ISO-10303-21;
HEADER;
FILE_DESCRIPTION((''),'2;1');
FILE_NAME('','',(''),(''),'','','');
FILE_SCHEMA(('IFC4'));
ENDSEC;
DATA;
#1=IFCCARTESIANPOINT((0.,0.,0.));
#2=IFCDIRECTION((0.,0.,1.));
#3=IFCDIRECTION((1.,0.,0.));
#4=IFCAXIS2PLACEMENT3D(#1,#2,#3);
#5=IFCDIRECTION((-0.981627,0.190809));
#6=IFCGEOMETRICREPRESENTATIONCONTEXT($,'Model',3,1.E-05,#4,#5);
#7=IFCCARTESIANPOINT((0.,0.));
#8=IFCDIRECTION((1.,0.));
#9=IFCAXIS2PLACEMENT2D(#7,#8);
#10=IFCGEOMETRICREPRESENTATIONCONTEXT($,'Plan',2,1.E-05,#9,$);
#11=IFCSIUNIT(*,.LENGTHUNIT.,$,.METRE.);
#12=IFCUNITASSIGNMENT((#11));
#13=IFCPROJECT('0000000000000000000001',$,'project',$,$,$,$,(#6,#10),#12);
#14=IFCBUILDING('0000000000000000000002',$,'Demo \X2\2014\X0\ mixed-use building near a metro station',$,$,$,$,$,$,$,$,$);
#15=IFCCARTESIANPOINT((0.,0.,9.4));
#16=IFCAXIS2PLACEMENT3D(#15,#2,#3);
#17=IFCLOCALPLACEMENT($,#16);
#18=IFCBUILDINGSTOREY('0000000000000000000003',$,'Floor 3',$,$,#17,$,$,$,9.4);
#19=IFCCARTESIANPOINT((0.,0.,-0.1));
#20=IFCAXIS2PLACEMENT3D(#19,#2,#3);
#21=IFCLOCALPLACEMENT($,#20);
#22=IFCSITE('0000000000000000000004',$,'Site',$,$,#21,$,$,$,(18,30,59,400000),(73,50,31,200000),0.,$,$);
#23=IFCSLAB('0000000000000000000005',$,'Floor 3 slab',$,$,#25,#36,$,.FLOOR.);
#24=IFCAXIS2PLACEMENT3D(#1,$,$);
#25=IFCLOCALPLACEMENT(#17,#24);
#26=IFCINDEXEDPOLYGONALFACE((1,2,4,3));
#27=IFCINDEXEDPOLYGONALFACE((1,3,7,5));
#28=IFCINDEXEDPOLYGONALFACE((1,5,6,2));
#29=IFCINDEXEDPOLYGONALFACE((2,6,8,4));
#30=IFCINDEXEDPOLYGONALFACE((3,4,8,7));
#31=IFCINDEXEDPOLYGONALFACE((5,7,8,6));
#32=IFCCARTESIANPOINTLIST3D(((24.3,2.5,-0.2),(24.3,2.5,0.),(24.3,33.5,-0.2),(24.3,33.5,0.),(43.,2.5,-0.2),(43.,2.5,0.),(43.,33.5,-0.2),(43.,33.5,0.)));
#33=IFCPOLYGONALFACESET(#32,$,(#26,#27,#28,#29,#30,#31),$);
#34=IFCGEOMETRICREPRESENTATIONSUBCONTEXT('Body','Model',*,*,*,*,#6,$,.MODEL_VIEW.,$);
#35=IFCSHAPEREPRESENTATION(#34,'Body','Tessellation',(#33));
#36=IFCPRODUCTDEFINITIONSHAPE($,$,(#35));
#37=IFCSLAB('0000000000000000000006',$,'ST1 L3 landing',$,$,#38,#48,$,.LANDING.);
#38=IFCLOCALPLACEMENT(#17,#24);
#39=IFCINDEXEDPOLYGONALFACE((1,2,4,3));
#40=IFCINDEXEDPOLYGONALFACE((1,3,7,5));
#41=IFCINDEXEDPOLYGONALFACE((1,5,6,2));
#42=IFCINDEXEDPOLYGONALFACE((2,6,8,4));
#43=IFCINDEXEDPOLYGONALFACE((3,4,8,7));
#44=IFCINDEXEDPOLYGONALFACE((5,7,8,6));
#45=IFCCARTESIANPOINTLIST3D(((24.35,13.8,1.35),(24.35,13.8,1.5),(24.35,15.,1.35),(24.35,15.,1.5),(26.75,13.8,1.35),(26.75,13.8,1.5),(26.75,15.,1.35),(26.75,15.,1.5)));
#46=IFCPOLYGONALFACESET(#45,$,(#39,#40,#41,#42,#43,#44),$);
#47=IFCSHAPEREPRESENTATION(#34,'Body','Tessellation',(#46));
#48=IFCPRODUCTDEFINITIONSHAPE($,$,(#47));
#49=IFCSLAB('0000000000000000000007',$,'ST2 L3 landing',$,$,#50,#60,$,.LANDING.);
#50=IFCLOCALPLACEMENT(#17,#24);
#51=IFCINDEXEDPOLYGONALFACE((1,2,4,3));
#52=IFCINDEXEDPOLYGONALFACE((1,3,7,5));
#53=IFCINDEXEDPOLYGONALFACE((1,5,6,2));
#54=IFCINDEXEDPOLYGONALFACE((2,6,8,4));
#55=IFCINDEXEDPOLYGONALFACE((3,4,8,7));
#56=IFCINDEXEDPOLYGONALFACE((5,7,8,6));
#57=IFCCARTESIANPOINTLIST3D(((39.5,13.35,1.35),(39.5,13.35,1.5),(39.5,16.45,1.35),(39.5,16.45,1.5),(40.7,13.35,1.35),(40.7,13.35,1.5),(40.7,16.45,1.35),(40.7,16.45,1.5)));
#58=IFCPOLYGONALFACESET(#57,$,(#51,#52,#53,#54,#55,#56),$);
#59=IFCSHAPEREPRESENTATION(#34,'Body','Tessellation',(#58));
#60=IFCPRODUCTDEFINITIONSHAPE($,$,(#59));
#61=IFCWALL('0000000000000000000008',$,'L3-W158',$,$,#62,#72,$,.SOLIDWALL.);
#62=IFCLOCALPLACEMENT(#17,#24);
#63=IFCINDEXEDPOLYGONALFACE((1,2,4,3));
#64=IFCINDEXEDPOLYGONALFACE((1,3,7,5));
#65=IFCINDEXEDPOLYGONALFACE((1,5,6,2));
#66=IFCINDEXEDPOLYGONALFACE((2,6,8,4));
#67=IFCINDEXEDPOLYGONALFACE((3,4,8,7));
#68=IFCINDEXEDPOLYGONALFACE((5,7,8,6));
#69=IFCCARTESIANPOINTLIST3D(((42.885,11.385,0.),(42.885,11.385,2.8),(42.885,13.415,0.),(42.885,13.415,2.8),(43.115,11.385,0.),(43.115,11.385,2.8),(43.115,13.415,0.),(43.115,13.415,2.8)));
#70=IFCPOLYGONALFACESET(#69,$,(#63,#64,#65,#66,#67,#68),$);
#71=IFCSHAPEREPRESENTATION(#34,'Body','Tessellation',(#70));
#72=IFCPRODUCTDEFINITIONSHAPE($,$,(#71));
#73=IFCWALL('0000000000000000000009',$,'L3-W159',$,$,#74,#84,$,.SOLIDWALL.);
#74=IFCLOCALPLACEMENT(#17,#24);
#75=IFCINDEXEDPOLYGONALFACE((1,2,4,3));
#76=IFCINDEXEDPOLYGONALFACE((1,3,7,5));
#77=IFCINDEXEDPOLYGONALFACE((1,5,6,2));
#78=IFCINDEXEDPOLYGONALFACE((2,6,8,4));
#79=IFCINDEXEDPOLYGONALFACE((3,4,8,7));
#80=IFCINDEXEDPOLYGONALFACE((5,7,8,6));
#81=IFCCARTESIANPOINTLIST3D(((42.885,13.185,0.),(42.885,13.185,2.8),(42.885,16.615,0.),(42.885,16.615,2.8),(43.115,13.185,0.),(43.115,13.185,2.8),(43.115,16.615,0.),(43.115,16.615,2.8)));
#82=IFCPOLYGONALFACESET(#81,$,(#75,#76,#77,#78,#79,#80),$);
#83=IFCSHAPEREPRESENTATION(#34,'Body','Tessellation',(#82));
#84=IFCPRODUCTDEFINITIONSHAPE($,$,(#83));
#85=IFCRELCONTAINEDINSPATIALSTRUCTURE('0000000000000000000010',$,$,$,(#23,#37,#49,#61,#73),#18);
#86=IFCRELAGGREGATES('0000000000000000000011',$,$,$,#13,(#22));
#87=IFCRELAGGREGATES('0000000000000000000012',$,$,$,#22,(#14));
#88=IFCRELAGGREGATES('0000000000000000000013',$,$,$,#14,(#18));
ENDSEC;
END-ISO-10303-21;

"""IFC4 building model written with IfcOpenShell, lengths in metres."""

from ifc_helpers import new_model, si_unit, direction, frame, origin_with_axes, origin_2d_with_axis, place, context, subcontext, project, spatial, line, indexed_curve, outline, extrude, element, save


model = new_model("IFC4")

# Units and contexts
model_context = context("Model", 3, precision=1e-05, world=origin_with_axes(), true_north=direction((-0.981627, 0.190809)))
plan_context = context("Plan", 2, precision=1e-05, world=origin_2d_with_axis())
body_context = subcontext(model_context, "Body", "Model", "MODEL_VIEW")
ifc_project = project(units=[si_unit("LENGTHUNIT", "METRE")], contexts=[model_context, plan_context])

# Site, building, storey
site_placement = place(None, frame((0.0, 0.0, -0.1), z_axis=(0.0, 0.0, 1.0), x_axis=(1.0, 0.0, 0.0)))
site = spatial("IfcSite", under=ifc_project, at=site_placement, Name="Site", RefLatitude=(18, 30, 59, 400000), RefLongitude=(73, 50, 31, 200000), RefElevation=0.0)
building = spatial("IfcBuilding", under=site, Name="Demo — mixed-use building near a metro station")
storey_placement = place(None, frame((0.0, 0.0, 9.4), z_axis=(0.0, 0.0, 1.0), x_axis=(1.0, 0.0, 0.0)))
storey = spatial("IfcBuildingStorey", under=building, at=storey_placement, Name="Floor 3", Elevation=9.4)

# Slabs
slab_1_placement = place(storey_placement, frame((0.0, 0.0, -0.2), z_axis=(0.0, 0.0, 1.0), x_axis=(1.0, 0.0, 0.0)))
element("IfcSlab", 1, at=slab_1_placement, inside=storey, Name="Floor 3 slab", PredefinedType="FLOOR", context=body_context, shape_type="SweptSolid", body=[
    extrude(outline(indexed_curve([(24.3, 2.5), (43.0, 2.5), (43.0, 33.5), (24.3, 33.5)], segments=[line(1, 2, 3, 4, 1)])), origin_with_axes(), (0.0, 0.0, 1.0), 0.2),
])
slab_2_placement = place(storey_placement, frame((0.0, 0.0, -9.4), z_axis=(0.0, 0.0, 1.0), x_axis=(1.0, 0.0, 0.0)))
element("IfcSlab", 2, at=slab_2_placement, inside=storey, Name="ST1 L3 landing", PredefinedType="LANDING", context=body_context, shape_type="SweptSolid", body=[
    extrude(outline(indexed_curve([(24.35, 13.8), (26.75, 13.8), (26.75, 15.0), (24.35, 15.0)], segments=[line(1, 2, 3, 4, 1)])), frame((0.0, 0.0, 10.75), z_axis=(0.0, 0.0, 1.0), x_axis=(1.0, 0.0, 0.0)), (0.0, 0.0, 1.0), 0.15),
])
slab_3_placement = place(storey_placement, frame((0.0, 0.0, -9.4), z_axis=(0.0, 0.0, 1.0), x_axis=(1.0, 0.0, 0.0)))
element("IfcSlab", 3, at=slab_3_placement, inside=storey, Name="ST2 L3 landing", PredefinedType="LANDING", context=body_context, shape_type="SweptSolid", body=[
    extrude(outline(indexed_curve([(39.5, 13.35), (39.5, 16.45), (40.7, 16.45), (40.7, 13.35)], segments=[line(1, 2, 3, 4, 1)])), frame((0.0, 0.0, 10.75), z_axis=(0.0, 0.0, 1.0), x_axis=(1.0, 0.0, 0.0)), (0.0, 0.0, 1.0), 0.15),
])

# Walls
wall_1_placement = place(storey_placement, frame((0.0, 0.0, -9.4), z_axis=(0.0, 0.0, 1.0), x_axis=(1.0, 0.0, 0.0)))
element("IfcWall", 4, at=wall_1_placement, inside=storey, Name="L3-W158", PredefinedType="SOLIDWALL", context=body_context, shape_type="SweptSolid", body=[
    extrude(outline(indexed_curve([(42.885, 11.385), (42.885, 13.415), (43.115, 13.415), (43.115, 11.385)], segments=[line(1, 2, 3, 4, 1)])), frame((0.0, 0.0, 9.4), z_axis=(0.0, 0.0, 1.0), x_axis=(1.0, 0.0, 0.0)), (0.0, 0.0, 1.0), 2.8),
])
wall_2_placement = place(storey_placement, frame((0.0, 0.0, -9.4), z_axis=(0.0, 0.0, 1.0), x_axis=(1.0, 0.0, 0.0)))
element("IfcWall", 5, at=wall_2_placement, inside=storey, Name="L3-W159", PredefinedType="SOLIDWALL", context=body_context, shape_type="SweptSolid", body=[
    extrude(outline(indexed_curve([(42.885, 13.185), (42.885, 16.615), (43.115, 16.615), (43.115, 13.185)], segments=[line(1, 2, 3, 4, 1)])), frame((0.0, 0.0, 9.4), z_axis=(0.0, 0.0, 1.0), x_axis=(1.0, 0.0, 0.0)), (0.0, 0.0, 1.0), 2.8),
])

save(model, "model.ifc")
